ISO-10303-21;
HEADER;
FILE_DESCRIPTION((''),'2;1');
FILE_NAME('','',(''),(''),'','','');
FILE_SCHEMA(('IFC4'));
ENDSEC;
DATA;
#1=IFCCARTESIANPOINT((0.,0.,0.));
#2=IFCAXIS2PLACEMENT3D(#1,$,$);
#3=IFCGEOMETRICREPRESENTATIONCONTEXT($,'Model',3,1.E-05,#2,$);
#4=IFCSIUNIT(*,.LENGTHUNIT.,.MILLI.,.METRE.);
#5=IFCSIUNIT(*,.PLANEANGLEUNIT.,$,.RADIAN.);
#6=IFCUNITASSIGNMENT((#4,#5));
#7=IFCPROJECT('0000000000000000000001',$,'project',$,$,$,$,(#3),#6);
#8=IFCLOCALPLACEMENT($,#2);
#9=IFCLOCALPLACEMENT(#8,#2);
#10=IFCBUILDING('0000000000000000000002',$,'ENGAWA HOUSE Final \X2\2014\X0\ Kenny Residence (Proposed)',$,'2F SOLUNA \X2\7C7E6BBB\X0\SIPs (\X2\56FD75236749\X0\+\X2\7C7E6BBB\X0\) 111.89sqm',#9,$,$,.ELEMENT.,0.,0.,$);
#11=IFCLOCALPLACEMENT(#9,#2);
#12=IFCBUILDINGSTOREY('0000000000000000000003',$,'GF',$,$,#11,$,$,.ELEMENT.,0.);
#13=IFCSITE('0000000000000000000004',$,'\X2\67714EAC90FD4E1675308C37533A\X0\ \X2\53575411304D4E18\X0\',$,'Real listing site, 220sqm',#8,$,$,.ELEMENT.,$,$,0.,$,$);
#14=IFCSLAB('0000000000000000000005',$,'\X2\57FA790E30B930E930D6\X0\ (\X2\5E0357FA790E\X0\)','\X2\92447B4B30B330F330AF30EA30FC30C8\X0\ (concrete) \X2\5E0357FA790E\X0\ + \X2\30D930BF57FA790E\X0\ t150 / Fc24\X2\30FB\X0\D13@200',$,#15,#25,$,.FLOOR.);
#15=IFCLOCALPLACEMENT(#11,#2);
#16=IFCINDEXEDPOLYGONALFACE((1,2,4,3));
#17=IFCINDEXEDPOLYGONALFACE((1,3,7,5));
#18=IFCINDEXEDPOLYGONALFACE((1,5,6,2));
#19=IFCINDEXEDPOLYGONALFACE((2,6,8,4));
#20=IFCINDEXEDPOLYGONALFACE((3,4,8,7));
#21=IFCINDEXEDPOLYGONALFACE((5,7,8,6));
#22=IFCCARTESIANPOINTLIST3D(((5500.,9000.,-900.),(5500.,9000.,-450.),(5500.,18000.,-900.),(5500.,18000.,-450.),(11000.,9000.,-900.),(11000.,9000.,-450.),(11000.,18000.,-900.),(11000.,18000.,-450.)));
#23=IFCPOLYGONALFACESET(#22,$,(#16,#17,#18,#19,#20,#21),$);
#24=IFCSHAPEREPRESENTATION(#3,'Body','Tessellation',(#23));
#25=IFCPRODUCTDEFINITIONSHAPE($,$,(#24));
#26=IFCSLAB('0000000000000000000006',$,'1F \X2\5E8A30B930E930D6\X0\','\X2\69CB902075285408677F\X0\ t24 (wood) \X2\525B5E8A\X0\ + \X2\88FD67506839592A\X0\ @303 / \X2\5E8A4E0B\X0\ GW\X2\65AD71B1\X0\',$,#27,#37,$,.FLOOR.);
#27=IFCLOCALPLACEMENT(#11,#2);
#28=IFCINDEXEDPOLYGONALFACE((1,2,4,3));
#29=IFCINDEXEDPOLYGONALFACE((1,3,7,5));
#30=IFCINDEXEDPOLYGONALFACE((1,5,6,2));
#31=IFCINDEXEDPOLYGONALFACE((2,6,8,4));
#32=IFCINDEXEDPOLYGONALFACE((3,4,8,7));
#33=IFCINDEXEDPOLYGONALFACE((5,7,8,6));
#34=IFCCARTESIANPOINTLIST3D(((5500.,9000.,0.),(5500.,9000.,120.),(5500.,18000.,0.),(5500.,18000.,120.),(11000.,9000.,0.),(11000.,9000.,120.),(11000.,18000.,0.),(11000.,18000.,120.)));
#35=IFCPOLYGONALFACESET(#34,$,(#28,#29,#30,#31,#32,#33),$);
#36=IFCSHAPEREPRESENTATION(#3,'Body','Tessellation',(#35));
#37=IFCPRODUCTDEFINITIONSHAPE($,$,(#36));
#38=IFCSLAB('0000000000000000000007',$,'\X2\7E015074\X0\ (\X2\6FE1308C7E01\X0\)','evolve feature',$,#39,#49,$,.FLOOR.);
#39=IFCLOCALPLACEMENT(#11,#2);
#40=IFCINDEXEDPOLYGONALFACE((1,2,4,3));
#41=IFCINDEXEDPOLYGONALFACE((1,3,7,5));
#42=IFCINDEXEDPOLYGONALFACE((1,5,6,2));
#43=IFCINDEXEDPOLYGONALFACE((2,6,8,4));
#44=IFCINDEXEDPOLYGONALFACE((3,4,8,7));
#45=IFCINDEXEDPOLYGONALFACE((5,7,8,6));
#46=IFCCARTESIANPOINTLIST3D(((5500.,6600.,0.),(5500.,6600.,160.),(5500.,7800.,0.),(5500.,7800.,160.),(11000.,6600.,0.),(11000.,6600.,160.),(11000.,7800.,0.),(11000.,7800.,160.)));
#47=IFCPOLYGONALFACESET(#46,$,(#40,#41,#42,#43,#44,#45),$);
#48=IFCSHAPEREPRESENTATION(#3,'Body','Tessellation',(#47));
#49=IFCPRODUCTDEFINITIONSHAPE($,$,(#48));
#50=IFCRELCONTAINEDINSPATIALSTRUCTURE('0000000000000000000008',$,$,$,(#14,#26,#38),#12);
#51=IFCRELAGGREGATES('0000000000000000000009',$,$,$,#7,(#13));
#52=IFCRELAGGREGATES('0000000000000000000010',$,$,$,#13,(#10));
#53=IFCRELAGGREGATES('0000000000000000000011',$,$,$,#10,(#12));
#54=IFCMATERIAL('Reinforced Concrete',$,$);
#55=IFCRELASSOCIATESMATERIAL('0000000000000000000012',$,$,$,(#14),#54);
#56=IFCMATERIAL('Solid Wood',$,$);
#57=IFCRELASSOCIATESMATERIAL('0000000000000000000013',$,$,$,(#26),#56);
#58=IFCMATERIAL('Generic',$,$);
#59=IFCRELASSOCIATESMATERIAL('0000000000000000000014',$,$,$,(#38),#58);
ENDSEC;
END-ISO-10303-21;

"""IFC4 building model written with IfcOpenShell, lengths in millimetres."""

from ifc_helpers import new_model, si_unit, frame, frame_2d, origin, place, context, project, spatial, rectangle, extrude, material, element, save


model = new_model("IFC4")

# Units and contexts
model_context = context("Model", 3, precision=1e-05, world=origin())
ifc_project = project(units=[si_unit("LENGTHUNIT", "METRE", prefix="MILLI"), si_unit("PLANEANGLEUNIT", "RADIAN")], contexts=[model_context])

# Site, building, storey
site_placement = place(None, origin())
site = spatial("IfcSite", under=ifc_project, at=site_placement, Name="東京都世田谷区 南向き丘", ObjectType="Real listing site, 220sqm", CompositionType="ELEMENT", RefElevation=0.0)
building_placement = place(site_placement, origin())
building = spatial("IfcBuilding", under=site, at=building_placement, Name="ENGAWA HOUSE Final — Kenny Residence (Proposed)", ObjectType="2F SOLUNA 籾殻SIPs (国産杉+籾殻) 111.89sqm", CompositionType="ELEMENT", ElevationOfRefHeight=0.0, ElevationOfTerrain=0.0)
storey_placement = place(building_placement, origin())
storey = spatial("IfcBuildingStorey", under=building, at=storey_placement, Name="GF", CompositionType="ELEMENT", Elevation=0.0)

# Slabs
ifc_material_1 = material(Name="Reinforced Concrete")
slab_1_placement = place(storey_placement, frame((2750.0, 4500.0, -450.0)))
element("IfcSlab", 1, at=slab_1_placement, inside=storey, material=ifc_material_1, Name="基礎スラブ (布基礎)", Description="鉄筋コンクリート (concrete) 布基礎 + ベタ基礎 t150 / Fc24・D13@200", PredefinedType="FLOOR", context=model_context, shape_type="SweptSolid", body=[
    extrude(rectangle(XDim=5500.0, YDim=9000.0, at=frame_2d((2750.0, 4500.0))), frame((2750.0, 4500.0, -450.0)), (0.0, 0.0, 1.0), 450.0),
])
ifc_material_2 = material(Name="Solid Wood")
slab_2_placement = place(storey_placement, frame((2750.0, 4500.0, 0.0)))
element("IfcSlab", 2, at=slab_2_placement, inside=storey, material=ifc_material_2, Name="1F 床スラブ", Description="構造用合板 t24 (wood) 剛床 + 製材根太 @303 / 床下 GW断熱", PredefinedType="FLOOR", context=model_context, shape_type="SweptSolid", body=[
    extrude(rectangle(XDim=5500.0, YDim=9000.0, at=frame_2d((2750.0, 4500.0))), frame((2750.0, 4500.0, 0.0)), (0.0, 0.0, 1.0), 120.0),
])
ifc_material_3 = material(Name="Generic")
slab_3_placement = place(storey_placement, frame((2750.0, 3300.0, 0.0)))
element("IfcSlab", 3, at=slab_3_placement, inside=storey, material=ifc_material_3, Name="縁側 (濡れ縁)", Description="evolve feature", PredefinedType="FLOOR", context=model_context, shape_type="SweptSolid", body=[
    extrude(rectangle(XDim=5500.0, YDim=1200.0, at=frame_2d((2750.0, 600.0))), frame((2750.0, 3300.0, 0.0)), (0.0, 0.0, 1.0), 160.0),
])

save(model, "model.ifc")
